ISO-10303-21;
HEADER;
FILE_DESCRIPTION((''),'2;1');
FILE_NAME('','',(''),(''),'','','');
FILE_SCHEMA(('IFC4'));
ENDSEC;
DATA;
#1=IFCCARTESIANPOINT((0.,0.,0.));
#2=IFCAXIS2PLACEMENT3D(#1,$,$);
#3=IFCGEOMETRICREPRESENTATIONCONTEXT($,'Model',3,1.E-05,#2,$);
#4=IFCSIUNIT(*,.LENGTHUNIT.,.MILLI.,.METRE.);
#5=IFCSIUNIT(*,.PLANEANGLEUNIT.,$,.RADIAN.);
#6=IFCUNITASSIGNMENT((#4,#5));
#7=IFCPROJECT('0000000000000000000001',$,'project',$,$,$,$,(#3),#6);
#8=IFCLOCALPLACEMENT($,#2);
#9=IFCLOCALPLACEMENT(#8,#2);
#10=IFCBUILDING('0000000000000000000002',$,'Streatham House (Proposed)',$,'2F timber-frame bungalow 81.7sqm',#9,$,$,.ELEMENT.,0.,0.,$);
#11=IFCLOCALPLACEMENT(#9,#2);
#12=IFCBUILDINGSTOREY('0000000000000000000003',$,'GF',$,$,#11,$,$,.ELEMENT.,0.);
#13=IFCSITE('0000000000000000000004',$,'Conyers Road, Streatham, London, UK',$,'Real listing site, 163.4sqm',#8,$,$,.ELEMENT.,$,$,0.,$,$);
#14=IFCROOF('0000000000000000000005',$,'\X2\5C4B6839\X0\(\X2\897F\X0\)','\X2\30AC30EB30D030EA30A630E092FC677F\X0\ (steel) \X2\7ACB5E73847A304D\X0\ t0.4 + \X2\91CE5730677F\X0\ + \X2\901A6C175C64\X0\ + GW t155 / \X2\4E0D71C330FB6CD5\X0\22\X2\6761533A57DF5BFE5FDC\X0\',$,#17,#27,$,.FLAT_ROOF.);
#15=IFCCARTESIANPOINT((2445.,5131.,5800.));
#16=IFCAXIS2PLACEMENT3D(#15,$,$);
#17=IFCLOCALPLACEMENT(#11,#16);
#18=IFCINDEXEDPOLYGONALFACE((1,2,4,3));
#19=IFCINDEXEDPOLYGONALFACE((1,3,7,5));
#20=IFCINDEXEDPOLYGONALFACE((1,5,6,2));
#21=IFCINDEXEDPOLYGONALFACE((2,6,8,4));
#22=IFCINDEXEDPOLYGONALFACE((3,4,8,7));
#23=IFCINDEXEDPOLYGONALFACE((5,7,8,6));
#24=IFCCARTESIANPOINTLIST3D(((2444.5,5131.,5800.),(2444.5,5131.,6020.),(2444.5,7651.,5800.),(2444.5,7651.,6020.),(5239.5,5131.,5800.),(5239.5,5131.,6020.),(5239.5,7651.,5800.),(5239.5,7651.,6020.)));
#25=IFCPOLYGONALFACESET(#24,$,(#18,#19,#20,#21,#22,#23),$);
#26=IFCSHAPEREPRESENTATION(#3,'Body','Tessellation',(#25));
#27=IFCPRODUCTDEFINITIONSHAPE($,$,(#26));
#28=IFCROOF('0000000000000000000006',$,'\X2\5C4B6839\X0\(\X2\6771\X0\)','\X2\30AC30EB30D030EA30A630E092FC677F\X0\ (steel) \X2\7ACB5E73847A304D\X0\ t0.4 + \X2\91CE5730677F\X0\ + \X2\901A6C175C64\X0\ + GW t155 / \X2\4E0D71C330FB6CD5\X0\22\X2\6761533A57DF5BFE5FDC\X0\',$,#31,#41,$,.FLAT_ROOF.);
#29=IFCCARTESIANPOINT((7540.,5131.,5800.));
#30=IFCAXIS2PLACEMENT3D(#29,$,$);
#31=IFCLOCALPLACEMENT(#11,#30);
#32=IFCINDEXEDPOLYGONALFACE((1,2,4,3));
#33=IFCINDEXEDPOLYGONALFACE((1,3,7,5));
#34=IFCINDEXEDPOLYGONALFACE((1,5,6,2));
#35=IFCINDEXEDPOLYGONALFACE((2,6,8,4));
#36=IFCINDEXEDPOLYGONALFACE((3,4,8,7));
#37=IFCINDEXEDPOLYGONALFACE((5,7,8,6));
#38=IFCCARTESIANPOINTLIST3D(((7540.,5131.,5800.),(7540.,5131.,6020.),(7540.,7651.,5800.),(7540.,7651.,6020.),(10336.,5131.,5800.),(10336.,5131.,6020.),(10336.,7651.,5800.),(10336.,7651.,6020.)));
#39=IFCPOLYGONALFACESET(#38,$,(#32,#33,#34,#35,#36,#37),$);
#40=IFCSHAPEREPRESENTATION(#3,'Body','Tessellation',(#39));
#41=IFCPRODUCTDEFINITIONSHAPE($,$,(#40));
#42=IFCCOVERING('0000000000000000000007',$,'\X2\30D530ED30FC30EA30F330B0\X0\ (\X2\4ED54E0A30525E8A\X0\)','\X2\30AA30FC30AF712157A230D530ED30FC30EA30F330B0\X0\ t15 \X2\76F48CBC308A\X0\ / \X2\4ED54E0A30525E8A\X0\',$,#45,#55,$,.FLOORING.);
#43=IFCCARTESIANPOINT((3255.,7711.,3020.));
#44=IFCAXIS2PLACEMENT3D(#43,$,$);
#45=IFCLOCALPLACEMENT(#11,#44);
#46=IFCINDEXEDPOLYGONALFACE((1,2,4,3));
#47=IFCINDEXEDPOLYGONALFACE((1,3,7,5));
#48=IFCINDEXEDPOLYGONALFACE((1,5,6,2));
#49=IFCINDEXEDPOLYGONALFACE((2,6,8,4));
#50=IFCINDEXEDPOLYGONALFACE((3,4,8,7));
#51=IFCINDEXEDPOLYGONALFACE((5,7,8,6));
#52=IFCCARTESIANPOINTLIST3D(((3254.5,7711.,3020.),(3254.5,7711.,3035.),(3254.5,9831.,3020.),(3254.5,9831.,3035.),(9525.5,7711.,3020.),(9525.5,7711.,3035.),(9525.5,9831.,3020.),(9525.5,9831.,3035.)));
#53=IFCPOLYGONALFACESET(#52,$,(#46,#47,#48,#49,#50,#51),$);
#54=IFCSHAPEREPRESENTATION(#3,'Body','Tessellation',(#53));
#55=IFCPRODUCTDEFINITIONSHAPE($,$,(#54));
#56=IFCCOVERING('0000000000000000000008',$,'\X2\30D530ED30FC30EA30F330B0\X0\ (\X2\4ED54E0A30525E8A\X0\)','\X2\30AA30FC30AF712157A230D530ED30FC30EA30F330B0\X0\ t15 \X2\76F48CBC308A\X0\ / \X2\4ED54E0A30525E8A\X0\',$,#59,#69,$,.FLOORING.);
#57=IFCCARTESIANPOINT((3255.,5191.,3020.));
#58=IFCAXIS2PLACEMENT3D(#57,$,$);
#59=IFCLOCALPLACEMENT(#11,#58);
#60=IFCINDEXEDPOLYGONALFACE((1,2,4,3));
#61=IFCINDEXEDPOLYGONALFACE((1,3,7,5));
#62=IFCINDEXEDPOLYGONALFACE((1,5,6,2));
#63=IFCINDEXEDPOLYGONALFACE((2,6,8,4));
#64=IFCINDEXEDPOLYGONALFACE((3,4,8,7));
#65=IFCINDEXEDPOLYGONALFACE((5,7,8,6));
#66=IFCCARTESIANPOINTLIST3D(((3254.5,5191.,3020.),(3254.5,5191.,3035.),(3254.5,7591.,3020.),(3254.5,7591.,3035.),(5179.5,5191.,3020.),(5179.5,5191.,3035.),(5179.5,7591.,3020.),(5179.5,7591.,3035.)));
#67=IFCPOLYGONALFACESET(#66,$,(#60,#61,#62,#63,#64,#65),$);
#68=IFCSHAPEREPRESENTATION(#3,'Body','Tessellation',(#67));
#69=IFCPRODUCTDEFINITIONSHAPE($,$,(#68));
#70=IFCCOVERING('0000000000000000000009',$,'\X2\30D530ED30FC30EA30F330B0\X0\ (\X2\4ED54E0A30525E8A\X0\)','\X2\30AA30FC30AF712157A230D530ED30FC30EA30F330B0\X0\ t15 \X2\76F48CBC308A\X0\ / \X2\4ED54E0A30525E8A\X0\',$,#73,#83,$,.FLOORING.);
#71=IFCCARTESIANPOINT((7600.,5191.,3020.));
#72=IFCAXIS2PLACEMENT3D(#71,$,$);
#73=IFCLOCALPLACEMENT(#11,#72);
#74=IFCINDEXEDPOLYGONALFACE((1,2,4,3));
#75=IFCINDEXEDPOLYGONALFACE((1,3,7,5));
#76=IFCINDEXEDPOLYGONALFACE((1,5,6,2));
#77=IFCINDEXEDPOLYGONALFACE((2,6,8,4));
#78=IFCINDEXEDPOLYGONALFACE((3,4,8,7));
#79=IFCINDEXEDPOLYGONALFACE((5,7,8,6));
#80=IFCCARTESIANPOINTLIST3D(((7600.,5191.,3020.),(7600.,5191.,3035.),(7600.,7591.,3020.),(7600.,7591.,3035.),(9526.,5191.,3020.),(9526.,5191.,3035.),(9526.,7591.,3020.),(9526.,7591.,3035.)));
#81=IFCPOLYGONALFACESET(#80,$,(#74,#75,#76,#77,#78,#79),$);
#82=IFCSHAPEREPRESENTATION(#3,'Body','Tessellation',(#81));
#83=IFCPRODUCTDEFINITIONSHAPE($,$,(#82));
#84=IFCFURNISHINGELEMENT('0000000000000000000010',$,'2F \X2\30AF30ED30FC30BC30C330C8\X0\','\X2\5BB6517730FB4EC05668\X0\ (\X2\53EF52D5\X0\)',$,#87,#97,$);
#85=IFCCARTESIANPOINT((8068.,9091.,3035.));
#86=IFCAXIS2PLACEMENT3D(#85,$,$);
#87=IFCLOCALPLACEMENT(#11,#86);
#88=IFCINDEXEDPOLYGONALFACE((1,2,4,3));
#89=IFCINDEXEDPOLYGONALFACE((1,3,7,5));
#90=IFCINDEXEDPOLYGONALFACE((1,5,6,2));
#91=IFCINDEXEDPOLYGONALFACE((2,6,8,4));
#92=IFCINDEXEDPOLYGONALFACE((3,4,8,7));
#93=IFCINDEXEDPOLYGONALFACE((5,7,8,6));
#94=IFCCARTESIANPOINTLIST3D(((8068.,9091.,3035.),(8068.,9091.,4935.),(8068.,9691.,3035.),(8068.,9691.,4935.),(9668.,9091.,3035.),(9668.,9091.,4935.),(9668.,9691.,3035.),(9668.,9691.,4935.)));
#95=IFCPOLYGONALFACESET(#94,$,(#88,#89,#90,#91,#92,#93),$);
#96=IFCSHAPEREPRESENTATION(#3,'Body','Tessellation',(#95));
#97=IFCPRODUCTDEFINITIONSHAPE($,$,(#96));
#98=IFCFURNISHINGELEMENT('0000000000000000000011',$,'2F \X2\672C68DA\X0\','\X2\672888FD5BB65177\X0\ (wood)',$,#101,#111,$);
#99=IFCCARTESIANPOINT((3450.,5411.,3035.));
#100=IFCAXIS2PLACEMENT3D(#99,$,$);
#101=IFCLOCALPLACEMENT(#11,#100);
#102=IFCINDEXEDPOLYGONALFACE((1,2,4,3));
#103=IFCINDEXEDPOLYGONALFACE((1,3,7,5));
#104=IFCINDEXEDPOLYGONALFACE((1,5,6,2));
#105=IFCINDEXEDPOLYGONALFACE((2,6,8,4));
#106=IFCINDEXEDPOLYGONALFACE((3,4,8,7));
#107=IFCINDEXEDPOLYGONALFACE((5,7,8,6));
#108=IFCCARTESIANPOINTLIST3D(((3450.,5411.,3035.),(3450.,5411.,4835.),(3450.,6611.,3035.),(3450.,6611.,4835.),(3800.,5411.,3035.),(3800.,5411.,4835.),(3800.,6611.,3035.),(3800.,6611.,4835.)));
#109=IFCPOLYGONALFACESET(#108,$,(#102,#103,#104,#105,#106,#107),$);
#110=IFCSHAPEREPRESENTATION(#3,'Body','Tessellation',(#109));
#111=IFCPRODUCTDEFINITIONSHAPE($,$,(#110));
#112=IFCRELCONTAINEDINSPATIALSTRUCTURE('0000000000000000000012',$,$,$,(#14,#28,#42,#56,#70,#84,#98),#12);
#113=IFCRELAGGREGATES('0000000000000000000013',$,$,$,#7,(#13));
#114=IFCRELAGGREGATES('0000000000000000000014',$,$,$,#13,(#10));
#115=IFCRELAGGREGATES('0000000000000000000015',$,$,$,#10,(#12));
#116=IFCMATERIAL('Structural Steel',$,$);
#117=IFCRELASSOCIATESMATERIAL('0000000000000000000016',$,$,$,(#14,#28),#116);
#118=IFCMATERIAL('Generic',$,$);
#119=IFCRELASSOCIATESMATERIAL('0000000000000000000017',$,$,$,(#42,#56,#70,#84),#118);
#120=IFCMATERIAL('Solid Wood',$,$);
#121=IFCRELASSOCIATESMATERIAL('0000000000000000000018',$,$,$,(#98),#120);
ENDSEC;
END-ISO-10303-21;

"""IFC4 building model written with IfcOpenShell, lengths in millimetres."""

from ifc_helpers import new_model, si_unit, frame, frame_2d, origin, place, context, project, spatial, rectangle, extrude, material, element, save


model = new_model("IFC4")

# Units and contexts
model_context = context("Model", 3, precision=1e-05, world=origin())
ifc_project = project(units=[si_unit("LENGTHUNIT", "METRE", prefix="MILLI"), si_unit("PLANEANGLEUNIT", "RADIAN")], contexts=[model_context])

# Site, building, storey
site_placement = place(None, origin())
site = spatial("IfcSite", under=ifc_project, at=site_placement, Name="Conyers Road, Streatham, London, UK", ObjectType="Real listing site, 163.4sqm", CompositionType="ELEMENT", RefElevation=0.0)
building_placement = place(site_placement, origin())
building = spatial("IfcBuilding", under=site, at=building_placement, Name="Streatham House (Proposed)", ObjectType="2F timber-frame bungalow 81.7sqm", CompositionType="ELEMENT", ElevationOfRefHeight=0.0, ElevationOfTerrain=0.0)
storey_placement = place(building_placement, origin())
storey = spatial("IfcBuildingStorey", under=building, at=storey_placement, Name="GF", CompositionType="ELEMENT", Elevation=0.0)

# Shared definitions
ifc_material_1 = material(Name="Solid Wood")

# Roofs
ifc_material_2 = material(Name="Structural Steel")
roof_1_placement = place(storey_placement, frame((2445.0, 5131.0, 5800.0)))
element("IfcRoof", 1, at=roof_1_placement, inside=storey, material=ifc_material_2, Name="屋根(西)", Description="ガルバリウム鋼板 (steel) 立平葺き t0.4 + 野地板 + 通気層 + GW t155 / 不燃・法22条区域対応", PredefinedType="FLAT_ROOF", context=model_context, shape_type="SweptSolid", body=[
    extrude(rectangle(XDim=2795.0, YDim=2520.0, at=frame_2d((1397.0, 1260.0))), frame((2445.0, 5131.0, 5800.0)), (0.0, 0.0, 1.0), 220.0),
])
roof_2_placement = place(storey_placement, frame((7540.0, 5131.0, 5800.0)))
element("IfcRoof", 2, at=roof_2_placement, inside=storey, material=ifc_material_2, Name="屋根(東)", Description="ガルバリウム鋼板 (steel) 立平葺き t0.4 + 野地板 + 通気層 + GW t155 / 不燃・法22条区域対応", PredefinedType="FLAT_ROOF", context=model_context, shape_type="SweptSolid", body=[
    extrude(rectangle(XDim=2796.0, YDim=2520.0, at=frame_2d((1398.0, 1260.0))), frame((7540.0, 5131.0, 5800.0)), (0.0, 0.0, 1.0), 220.0),
])

# Coverings
ifc_material_3 = material(Name="Generic")
covering_1_placement = place(storey_placement, frame((3255.0, 7711.0, 3020.0)))
element("IfcCovering", 3, at=covering_1_placement, inside=storey, material=ifc_material_3, Name="フローリング (仕上げ床)", Description="オーク無垢フローリング t15 直貼り / 仕上げ床", PredefinedType="FLOORING", context=model_context, shape_type="SweptSolid", body=[
    extrude(rectangle(XDim=6271.0, YDim=2120.0, at=frame_2d((3135.0, 1060.0))), frame((3255.0, 7711.0, 3020.0)), (0.0, 0.0, 1.0), 15.0),
])
covering_2_placement = place(storey_placement, frame((3255.0, 5191.0, 3020.0)))
element("IfcCovering", 4, at=covering_2_placement, inside=storey, material=ifc_material_3, Name="フローリング (仕上げ床)", Description="オーク無垢フローリング t15 直貼り / 仕上げ床", PredefinedType="FLOORING", context=model_context, shape_type="SweptSolid", body=[
    extrude(rectangle(XDim=1925.0, YDim=2400.0, at=frame_2d((962.0, 1200.0))), frame((3255.0, 5191.0, 3020.0)), (0.0, 0.0, 1.0), 15.0),
])
covering_3_placement = place(storey_placement, frame((7600.0, 5191.0, 3020.0)))
element("IfcCovering", 5, at=covering_3_placement, inside=storey, material=ifc_material_3, Name="フローリング (仕上げ床)", Description="オーク無垢フローリング t15 直貼り / 仕上げ床", PredefinedType="FLOORING", context=model_context, shape_type="SweptSolid", body=[
    extrude(rectangle(XDim=1926.0, YDim=2400.0, at=frame_2d((963.0, 1200.0))), frame((7600.0, 5191.0, 3020.0)), (0.0, 0.0, 1.0), 15.0),
])

# Furnishing elements
furnishing_1_placement = place(storey_placement, frame((8068.0, 9091.0, 3035.0)))
element("IfcFurnishingElement", 6, at=furnishing_1_placement, inside=storey, material=ifc_material_3, Name="2F クローゼット", Description="家具・什器 (可動)", context=model_context, shape_type="SweptSolid", body=[
    extrude(rectangle(XDim=1600.0, YDim=600.0, at=frame_2d((800.0, 300.0))), frame((8068.0, 9091.0, 3035.0)), (0.0, 0.0, 1.0), 1900.0),
])
furnishing_2_placement = place(storey_placement, frame((3450.0, 5411.0, 3035.0)))
element("IfcFurnishingElement", 7, at=furnishing_2_placement, inside=storey, material=ifc_material_1, Name="2F 本棚", Description="木製家具 (wood)", context=model_context, shape_type="SweptSolid", body=[
    extrude(rectangle(XDim=350.0, YDim=1200.0, at=frame_2d((175.0, 600.0))), frame((3450.0, 5411.0, 3035.0)), (0.0, 0.0, 1.0), 1800.0),
])

save(model, "model.ifc")
